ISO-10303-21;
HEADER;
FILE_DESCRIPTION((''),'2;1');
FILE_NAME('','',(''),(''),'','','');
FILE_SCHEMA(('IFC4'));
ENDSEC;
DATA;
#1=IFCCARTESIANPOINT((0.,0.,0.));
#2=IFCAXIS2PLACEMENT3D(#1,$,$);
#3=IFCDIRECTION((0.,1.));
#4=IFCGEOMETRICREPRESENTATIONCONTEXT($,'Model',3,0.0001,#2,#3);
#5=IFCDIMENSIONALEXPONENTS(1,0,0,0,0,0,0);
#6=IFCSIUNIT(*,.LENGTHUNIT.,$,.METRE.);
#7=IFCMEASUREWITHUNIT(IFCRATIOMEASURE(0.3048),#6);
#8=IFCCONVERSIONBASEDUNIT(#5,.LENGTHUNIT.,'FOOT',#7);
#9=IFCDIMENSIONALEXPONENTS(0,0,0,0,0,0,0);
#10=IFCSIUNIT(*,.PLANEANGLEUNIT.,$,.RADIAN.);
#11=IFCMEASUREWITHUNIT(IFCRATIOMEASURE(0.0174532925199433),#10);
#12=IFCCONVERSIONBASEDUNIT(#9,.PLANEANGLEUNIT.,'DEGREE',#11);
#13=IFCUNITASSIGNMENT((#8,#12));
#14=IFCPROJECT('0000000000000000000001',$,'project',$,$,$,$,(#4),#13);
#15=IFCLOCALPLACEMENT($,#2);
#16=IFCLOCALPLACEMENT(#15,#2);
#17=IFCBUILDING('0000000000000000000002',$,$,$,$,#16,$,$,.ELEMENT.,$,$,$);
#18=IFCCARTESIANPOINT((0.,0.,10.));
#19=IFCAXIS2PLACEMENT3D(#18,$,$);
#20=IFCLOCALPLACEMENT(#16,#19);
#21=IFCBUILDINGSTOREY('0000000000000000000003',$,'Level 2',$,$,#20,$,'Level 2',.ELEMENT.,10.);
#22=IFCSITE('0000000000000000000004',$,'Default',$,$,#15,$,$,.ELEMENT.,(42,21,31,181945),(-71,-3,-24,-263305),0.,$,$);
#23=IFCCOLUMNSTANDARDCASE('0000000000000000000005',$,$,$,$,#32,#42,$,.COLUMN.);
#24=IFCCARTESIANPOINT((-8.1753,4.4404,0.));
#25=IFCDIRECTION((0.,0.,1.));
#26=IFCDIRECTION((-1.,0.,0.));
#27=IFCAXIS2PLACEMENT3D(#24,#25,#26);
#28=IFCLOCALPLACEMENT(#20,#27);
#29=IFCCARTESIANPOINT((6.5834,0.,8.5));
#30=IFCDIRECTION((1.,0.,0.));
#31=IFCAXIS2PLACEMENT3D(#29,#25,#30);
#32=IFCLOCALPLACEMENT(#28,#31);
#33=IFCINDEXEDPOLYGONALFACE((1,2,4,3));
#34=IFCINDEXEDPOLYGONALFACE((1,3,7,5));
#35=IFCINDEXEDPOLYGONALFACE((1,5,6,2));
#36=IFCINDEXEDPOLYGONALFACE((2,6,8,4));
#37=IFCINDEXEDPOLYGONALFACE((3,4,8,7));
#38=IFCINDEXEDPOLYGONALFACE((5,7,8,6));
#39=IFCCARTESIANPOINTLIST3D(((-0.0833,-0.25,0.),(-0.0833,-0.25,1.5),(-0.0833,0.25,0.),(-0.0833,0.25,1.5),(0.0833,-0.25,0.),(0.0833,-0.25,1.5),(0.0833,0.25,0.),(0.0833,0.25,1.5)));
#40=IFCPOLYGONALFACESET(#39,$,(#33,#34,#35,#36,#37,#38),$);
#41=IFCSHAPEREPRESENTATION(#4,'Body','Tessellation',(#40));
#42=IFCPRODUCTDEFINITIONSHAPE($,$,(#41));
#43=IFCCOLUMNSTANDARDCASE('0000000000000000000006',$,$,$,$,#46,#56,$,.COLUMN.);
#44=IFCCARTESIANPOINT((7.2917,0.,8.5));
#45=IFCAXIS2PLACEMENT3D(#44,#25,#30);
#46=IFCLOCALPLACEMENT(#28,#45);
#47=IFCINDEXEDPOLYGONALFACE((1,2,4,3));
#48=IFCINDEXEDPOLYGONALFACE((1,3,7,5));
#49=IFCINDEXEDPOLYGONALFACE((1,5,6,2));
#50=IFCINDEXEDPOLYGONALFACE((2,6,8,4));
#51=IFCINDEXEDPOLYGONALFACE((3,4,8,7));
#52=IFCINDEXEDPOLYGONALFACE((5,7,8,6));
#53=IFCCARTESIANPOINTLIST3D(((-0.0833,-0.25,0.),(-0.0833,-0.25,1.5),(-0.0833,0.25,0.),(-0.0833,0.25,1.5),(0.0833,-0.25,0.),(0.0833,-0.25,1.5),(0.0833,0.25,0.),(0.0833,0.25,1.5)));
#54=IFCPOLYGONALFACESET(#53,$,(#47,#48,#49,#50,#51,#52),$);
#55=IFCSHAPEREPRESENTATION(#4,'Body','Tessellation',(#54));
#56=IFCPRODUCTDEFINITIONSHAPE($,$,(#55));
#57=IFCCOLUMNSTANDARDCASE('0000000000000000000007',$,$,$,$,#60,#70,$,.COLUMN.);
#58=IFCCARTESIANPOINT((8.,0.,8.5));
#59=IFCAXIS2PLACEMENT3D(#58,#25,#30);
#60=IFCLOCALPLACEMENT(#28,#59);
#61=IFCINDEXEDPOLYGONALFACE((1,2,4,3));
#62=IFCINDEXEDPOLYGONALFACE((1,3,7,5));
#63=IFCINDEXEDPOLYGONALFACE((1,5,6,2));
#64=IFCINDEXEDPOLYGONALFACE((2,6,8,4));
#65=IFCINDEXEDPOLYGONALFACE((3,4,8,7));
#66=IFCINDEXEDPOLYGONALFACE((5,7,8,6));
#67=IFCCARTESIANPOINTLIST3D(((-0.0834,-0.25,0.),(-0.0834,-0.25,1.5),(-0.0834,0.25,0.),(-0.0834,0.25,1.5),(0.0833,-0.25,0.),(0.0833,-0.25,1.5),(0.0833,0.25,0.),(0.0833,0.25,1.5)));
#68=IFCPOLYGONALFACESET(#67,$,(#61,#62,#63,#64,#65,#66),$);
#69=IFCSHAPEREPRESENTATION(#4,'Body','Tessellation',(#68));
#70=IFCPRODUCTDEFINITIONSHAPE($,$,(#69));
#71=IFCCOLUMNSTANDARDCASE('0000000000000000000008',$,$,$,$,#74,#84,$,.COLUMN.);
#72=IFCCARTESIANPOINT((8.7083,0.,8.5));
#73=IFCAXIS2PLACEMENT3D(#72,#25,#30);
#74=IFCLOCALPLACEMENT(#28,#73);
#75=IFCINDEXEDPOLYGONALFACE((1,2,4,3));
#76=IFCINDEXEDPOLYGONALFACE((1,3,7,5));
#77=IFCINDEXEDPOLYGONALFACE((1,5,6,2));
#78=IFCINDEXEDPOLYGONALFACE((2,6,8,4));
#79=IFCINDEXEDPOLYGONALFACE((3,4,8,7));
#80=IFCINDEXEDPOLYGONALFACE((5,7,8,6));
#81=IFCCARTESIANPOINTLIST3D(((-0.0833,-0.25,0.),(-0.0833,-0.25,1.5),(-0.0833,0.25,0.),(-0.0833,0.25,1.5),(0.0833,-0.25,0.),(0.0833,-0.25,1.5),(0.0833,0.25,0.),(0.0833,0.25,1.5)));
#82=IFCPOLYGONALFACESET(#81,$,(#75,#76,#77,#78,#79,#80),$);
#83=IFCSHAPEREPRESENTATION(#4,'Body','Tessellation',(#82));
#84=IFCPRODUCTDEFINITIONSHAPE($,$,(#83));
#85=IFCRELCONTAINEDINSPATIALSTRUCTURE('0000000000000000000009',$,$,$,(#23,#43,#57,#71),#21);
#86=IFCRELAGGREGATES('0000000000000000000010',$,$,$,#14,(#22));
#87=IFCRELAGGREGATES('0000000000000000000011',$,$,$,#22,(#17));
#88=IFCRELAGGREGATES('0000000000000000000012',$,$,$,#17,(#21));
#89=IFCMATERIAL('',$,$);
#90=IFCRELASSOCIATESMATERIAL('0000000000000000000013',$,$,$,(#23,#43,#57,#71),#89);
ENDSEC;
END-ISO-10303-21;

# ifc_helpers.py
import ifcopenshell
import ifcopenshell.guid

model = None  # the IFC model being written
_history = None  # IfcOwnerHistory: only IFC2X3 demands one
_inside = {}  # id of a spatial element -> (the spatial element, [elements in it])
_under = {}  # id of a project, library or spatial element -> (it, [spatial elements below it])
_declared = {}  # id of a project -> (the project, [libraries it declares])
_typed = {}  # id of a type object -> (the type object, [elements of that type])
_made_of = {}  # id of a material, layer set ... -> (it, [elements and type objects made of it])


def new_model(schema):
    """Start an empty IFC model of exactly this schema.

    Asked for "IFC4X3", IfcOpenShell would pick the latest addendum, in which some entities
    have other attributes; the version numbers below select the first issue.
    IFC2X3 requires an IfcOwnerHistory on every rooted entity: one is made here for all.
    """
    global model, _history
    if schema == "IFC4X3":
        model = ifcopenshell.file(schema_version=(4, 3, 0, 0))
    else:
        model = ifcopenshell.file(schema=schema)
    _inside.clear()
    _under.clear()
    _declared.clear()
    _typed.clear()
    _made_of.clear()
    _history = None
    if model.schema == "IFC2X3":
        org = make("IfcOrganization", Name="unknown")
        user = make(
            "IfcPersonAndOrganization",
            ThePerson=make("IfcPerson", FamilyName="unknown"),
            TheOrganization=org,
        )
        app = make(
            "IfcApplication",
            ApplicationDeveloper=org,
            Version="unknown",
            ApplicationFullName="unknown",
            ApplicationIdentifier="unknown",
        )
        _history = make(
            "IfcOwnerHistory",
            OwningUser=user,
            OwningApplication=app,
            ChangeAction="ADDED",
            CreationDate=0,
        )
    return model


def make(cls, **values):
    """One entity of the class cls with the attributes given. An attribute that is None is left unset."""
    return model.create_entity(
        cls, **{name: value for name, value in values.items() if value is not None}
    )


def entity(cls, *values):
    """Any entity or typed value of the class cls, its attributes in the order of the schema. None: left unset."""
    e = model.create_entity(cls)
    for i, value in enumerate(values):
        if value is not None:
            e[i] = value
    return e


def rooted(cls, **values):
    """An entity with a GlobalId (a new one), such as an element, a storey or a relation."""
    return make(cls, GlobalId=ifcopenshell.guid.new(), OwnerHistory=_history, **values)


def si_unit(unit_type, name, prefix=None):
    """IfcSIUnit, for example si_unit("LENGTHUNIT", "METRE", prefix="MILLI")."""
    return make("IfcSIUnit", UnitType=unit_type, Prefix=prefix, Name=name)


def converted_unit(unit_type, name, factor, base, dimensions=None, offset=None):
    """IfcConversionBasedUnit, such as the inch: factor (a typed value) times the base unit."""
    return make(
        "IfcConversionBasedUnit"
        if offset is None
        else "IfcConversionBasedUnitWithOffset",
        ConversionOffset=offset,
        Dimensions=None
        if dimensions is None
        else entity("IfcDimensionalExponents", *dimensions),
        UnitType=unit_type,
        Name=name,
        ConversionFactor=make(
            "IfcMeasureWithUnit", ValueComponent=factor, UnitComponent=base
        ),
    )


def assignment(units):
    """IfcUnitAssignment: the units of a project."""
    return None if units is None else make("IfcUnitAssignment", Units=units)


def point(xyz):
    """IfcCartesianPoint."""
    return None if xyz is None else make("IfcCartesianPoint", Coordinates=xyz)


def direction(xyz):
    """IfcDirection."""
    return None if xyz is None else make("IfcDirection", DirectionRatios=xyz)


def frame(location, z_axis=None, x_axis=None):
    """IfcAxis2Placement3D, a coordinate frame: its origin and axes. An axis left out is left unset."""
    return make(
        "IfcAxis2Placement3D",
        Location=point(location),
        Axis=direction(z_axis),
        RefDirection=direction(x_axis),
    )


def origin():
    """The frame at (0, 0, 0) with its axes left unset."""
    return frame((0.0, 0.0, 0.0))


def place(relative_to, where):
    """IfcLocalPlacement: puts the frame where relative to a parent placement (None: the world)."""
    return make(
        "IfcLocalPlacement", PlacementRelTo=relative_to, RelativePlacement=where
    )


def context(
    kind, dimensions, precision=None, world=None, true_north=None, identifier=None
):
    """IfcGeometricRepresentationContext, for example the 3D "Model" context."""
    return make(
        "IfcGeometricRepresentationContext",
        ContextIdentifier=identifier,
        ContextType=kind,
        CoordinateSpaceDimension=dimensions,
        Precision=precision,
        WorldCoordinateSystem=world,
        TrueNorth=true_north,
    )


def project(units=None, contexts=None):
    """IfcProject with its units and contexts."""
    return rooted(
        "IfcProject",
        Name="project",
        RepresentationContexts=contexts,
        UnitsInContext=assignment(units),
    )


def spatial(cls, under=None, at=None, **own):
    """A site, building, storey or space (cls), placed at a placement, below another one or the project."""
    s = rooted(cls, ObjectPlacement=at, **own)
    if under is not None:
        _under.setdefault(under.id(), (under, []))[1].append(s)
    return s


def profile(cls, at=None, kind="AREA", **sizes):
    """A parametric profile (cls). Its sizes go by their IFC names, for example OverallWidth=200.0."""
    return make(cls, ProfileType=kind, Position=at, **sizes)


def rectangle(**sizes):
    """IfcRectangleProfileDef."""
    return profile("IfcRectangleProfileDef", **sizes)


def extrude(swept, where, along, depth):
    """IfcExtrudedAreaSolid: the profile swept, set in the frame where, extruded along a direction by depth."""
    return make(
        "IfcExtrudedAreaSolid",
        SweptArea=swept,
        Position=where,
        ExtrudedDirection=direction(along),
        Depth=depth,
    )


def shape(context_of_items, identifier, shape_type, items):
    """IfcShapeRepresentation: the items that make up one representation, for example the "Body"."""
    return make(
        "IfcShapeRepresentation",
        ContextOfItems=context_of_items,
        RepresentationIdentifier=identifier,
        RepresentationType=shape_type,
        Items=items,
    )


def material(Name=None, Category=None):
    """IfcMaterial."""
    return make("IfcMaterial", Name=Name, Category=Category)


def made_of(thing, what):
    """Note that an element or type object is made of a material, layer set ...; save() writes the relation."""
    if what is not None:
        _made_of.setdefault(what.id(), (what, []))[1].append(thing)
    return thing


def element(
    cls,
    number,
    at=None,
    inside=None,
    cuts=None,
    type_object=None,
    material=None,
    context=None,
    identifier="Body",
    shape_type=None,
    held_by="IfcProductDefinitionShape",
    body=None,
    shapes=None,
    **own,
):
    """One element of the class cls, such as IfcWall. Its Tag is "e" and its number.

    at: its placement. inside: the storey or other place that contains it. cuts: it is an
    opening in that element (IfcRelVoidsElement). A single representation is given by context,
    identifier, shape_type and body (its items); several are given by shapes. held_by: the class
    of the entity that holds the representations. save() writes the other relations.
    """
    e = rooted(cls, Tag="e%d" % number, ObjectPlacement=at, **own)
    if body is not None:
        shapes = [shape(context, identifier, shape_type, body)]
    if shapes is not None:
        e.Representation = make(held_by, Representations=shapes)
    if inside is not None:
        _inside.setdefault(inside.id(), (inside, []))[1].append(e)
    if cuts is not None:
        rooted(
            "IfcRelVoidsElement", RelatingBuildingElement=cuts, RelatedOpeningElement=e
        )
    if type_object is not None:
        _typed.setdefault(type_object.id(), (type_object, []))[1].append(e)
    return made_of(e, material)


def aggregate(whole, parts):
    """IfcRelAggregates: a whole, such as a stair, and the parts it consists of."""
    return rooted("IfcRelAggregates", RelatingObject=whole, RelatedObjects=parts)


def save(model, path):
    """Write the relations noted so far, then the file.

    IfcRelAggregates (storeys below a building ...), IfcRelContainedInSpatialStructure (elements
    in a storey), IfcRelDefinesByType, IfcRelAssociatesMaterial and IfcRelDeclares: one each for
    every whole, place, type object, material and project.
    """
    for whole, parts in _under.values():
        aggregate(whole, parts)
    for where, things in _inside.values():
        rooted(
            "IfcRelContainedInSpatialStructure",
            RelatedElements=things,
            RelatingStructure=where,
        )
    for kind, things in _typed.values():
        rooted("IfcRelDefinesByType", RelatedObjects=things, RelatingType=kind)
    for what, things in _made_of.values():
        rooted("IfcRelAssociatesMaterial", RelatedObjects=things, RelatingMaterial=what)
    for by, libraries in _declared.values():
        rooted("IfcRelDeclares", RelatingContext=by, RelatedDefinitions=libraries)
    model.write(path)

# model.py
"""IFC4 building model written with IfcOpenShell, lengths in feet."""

from ifc_helpers import new_model, entity, si_unit, converted_unit, direction, frame, origin, place, context, project, spatial, rectangle, extrude, material, element, save


model = new_model("IFC4")

# Units and contexts
model_context = context("Model", 3, precision=0.0001, world=origin(), true_north=direction((0.0, 1.0)))
ifc_project = project(units=[converted_unit("LENGTHUNIT", "FOOT", entity("IfcRatioMeasure", 0.3048), si_unit("LENGTHUNIT", "METRE"), dimensions=[1, 0, 0, 0, 0, 0, 0]), converted_unit("PLANEANGLEUNIT", "DEGREE", entity("IfcRatioMeasure", 0.0174532925199433), si_unit("PLANEANGLEUNIT", "RADIAN"), dimensions=[0, 0, 0, 0, 0, 0, 0])], contexts=[model_context])

# Site, building, storey
site_placement = place(None, origin())
site = spatial("IfcSite", under=ifc_project, at=site_placement, Name="Default", CompositionType="ELEMENT", RefLatitude=(42, 21, 31, 181945), RefLongitude=(-71, -3, -24, -263305), RefElevation=0.0)
building_placement = place(site_placement, origin())
building = spatial("IfcBuilding", under=site, at=building_placement, CompositionType="ELEMENT")
storey_placement = place(building_placement, frame((0.0, 0.0, 10.0)))
storey = spatial("IfcBuildingStorey", under=building, at=storey_placement, Name="Level 2", LongName="Level 2", CompositionType="ELEMENT", Elevation=10.0)

# Columns
placement_1 = place(storey_placement, frame((-8.1753, 4.4404, 0.0), z_axis=(0.0, 0.0, 1.0), x_axis=(-1.0, 0.0, 0.0)))
ifc_material_1 = material(Name="")
for number, where, z_axis, x_axis in (
    (1, (6.5834, 0.0, 8.5), (0.0, 0.0, 1.0), (1.0, 0.0, 0.0)),
    (2, (7.2917, 0.0, 8.5), (0.0, 0.0, 1.0), (1.0, 0.0, 0.0)),
    (3, (8.0, 0.0, 8.5), (0.0, 0.0, 1.0), (1.0, 0.0, 0.0)),
    (4, (8.7083, 0.0, 8.5), (0.0, 0.0, 1.0), (1.0, 0.0, 0.0)),
):
    element("IfcColumnStandardCase", number, at=place(placement_1, frame(where, z_axis=z_axis, x_axis=x_axis)), inside=storey, material=ifc_material_1, PredefinedType="COLUMN", context=model_context, shape_type="SweptSolid", body=[
        extrude(rectangle(XDim=0.1667, YDim=0.5), origin(), (0.0, 0.0, 1.0), 1.5),
    ])

save(model, "model.ifc")
